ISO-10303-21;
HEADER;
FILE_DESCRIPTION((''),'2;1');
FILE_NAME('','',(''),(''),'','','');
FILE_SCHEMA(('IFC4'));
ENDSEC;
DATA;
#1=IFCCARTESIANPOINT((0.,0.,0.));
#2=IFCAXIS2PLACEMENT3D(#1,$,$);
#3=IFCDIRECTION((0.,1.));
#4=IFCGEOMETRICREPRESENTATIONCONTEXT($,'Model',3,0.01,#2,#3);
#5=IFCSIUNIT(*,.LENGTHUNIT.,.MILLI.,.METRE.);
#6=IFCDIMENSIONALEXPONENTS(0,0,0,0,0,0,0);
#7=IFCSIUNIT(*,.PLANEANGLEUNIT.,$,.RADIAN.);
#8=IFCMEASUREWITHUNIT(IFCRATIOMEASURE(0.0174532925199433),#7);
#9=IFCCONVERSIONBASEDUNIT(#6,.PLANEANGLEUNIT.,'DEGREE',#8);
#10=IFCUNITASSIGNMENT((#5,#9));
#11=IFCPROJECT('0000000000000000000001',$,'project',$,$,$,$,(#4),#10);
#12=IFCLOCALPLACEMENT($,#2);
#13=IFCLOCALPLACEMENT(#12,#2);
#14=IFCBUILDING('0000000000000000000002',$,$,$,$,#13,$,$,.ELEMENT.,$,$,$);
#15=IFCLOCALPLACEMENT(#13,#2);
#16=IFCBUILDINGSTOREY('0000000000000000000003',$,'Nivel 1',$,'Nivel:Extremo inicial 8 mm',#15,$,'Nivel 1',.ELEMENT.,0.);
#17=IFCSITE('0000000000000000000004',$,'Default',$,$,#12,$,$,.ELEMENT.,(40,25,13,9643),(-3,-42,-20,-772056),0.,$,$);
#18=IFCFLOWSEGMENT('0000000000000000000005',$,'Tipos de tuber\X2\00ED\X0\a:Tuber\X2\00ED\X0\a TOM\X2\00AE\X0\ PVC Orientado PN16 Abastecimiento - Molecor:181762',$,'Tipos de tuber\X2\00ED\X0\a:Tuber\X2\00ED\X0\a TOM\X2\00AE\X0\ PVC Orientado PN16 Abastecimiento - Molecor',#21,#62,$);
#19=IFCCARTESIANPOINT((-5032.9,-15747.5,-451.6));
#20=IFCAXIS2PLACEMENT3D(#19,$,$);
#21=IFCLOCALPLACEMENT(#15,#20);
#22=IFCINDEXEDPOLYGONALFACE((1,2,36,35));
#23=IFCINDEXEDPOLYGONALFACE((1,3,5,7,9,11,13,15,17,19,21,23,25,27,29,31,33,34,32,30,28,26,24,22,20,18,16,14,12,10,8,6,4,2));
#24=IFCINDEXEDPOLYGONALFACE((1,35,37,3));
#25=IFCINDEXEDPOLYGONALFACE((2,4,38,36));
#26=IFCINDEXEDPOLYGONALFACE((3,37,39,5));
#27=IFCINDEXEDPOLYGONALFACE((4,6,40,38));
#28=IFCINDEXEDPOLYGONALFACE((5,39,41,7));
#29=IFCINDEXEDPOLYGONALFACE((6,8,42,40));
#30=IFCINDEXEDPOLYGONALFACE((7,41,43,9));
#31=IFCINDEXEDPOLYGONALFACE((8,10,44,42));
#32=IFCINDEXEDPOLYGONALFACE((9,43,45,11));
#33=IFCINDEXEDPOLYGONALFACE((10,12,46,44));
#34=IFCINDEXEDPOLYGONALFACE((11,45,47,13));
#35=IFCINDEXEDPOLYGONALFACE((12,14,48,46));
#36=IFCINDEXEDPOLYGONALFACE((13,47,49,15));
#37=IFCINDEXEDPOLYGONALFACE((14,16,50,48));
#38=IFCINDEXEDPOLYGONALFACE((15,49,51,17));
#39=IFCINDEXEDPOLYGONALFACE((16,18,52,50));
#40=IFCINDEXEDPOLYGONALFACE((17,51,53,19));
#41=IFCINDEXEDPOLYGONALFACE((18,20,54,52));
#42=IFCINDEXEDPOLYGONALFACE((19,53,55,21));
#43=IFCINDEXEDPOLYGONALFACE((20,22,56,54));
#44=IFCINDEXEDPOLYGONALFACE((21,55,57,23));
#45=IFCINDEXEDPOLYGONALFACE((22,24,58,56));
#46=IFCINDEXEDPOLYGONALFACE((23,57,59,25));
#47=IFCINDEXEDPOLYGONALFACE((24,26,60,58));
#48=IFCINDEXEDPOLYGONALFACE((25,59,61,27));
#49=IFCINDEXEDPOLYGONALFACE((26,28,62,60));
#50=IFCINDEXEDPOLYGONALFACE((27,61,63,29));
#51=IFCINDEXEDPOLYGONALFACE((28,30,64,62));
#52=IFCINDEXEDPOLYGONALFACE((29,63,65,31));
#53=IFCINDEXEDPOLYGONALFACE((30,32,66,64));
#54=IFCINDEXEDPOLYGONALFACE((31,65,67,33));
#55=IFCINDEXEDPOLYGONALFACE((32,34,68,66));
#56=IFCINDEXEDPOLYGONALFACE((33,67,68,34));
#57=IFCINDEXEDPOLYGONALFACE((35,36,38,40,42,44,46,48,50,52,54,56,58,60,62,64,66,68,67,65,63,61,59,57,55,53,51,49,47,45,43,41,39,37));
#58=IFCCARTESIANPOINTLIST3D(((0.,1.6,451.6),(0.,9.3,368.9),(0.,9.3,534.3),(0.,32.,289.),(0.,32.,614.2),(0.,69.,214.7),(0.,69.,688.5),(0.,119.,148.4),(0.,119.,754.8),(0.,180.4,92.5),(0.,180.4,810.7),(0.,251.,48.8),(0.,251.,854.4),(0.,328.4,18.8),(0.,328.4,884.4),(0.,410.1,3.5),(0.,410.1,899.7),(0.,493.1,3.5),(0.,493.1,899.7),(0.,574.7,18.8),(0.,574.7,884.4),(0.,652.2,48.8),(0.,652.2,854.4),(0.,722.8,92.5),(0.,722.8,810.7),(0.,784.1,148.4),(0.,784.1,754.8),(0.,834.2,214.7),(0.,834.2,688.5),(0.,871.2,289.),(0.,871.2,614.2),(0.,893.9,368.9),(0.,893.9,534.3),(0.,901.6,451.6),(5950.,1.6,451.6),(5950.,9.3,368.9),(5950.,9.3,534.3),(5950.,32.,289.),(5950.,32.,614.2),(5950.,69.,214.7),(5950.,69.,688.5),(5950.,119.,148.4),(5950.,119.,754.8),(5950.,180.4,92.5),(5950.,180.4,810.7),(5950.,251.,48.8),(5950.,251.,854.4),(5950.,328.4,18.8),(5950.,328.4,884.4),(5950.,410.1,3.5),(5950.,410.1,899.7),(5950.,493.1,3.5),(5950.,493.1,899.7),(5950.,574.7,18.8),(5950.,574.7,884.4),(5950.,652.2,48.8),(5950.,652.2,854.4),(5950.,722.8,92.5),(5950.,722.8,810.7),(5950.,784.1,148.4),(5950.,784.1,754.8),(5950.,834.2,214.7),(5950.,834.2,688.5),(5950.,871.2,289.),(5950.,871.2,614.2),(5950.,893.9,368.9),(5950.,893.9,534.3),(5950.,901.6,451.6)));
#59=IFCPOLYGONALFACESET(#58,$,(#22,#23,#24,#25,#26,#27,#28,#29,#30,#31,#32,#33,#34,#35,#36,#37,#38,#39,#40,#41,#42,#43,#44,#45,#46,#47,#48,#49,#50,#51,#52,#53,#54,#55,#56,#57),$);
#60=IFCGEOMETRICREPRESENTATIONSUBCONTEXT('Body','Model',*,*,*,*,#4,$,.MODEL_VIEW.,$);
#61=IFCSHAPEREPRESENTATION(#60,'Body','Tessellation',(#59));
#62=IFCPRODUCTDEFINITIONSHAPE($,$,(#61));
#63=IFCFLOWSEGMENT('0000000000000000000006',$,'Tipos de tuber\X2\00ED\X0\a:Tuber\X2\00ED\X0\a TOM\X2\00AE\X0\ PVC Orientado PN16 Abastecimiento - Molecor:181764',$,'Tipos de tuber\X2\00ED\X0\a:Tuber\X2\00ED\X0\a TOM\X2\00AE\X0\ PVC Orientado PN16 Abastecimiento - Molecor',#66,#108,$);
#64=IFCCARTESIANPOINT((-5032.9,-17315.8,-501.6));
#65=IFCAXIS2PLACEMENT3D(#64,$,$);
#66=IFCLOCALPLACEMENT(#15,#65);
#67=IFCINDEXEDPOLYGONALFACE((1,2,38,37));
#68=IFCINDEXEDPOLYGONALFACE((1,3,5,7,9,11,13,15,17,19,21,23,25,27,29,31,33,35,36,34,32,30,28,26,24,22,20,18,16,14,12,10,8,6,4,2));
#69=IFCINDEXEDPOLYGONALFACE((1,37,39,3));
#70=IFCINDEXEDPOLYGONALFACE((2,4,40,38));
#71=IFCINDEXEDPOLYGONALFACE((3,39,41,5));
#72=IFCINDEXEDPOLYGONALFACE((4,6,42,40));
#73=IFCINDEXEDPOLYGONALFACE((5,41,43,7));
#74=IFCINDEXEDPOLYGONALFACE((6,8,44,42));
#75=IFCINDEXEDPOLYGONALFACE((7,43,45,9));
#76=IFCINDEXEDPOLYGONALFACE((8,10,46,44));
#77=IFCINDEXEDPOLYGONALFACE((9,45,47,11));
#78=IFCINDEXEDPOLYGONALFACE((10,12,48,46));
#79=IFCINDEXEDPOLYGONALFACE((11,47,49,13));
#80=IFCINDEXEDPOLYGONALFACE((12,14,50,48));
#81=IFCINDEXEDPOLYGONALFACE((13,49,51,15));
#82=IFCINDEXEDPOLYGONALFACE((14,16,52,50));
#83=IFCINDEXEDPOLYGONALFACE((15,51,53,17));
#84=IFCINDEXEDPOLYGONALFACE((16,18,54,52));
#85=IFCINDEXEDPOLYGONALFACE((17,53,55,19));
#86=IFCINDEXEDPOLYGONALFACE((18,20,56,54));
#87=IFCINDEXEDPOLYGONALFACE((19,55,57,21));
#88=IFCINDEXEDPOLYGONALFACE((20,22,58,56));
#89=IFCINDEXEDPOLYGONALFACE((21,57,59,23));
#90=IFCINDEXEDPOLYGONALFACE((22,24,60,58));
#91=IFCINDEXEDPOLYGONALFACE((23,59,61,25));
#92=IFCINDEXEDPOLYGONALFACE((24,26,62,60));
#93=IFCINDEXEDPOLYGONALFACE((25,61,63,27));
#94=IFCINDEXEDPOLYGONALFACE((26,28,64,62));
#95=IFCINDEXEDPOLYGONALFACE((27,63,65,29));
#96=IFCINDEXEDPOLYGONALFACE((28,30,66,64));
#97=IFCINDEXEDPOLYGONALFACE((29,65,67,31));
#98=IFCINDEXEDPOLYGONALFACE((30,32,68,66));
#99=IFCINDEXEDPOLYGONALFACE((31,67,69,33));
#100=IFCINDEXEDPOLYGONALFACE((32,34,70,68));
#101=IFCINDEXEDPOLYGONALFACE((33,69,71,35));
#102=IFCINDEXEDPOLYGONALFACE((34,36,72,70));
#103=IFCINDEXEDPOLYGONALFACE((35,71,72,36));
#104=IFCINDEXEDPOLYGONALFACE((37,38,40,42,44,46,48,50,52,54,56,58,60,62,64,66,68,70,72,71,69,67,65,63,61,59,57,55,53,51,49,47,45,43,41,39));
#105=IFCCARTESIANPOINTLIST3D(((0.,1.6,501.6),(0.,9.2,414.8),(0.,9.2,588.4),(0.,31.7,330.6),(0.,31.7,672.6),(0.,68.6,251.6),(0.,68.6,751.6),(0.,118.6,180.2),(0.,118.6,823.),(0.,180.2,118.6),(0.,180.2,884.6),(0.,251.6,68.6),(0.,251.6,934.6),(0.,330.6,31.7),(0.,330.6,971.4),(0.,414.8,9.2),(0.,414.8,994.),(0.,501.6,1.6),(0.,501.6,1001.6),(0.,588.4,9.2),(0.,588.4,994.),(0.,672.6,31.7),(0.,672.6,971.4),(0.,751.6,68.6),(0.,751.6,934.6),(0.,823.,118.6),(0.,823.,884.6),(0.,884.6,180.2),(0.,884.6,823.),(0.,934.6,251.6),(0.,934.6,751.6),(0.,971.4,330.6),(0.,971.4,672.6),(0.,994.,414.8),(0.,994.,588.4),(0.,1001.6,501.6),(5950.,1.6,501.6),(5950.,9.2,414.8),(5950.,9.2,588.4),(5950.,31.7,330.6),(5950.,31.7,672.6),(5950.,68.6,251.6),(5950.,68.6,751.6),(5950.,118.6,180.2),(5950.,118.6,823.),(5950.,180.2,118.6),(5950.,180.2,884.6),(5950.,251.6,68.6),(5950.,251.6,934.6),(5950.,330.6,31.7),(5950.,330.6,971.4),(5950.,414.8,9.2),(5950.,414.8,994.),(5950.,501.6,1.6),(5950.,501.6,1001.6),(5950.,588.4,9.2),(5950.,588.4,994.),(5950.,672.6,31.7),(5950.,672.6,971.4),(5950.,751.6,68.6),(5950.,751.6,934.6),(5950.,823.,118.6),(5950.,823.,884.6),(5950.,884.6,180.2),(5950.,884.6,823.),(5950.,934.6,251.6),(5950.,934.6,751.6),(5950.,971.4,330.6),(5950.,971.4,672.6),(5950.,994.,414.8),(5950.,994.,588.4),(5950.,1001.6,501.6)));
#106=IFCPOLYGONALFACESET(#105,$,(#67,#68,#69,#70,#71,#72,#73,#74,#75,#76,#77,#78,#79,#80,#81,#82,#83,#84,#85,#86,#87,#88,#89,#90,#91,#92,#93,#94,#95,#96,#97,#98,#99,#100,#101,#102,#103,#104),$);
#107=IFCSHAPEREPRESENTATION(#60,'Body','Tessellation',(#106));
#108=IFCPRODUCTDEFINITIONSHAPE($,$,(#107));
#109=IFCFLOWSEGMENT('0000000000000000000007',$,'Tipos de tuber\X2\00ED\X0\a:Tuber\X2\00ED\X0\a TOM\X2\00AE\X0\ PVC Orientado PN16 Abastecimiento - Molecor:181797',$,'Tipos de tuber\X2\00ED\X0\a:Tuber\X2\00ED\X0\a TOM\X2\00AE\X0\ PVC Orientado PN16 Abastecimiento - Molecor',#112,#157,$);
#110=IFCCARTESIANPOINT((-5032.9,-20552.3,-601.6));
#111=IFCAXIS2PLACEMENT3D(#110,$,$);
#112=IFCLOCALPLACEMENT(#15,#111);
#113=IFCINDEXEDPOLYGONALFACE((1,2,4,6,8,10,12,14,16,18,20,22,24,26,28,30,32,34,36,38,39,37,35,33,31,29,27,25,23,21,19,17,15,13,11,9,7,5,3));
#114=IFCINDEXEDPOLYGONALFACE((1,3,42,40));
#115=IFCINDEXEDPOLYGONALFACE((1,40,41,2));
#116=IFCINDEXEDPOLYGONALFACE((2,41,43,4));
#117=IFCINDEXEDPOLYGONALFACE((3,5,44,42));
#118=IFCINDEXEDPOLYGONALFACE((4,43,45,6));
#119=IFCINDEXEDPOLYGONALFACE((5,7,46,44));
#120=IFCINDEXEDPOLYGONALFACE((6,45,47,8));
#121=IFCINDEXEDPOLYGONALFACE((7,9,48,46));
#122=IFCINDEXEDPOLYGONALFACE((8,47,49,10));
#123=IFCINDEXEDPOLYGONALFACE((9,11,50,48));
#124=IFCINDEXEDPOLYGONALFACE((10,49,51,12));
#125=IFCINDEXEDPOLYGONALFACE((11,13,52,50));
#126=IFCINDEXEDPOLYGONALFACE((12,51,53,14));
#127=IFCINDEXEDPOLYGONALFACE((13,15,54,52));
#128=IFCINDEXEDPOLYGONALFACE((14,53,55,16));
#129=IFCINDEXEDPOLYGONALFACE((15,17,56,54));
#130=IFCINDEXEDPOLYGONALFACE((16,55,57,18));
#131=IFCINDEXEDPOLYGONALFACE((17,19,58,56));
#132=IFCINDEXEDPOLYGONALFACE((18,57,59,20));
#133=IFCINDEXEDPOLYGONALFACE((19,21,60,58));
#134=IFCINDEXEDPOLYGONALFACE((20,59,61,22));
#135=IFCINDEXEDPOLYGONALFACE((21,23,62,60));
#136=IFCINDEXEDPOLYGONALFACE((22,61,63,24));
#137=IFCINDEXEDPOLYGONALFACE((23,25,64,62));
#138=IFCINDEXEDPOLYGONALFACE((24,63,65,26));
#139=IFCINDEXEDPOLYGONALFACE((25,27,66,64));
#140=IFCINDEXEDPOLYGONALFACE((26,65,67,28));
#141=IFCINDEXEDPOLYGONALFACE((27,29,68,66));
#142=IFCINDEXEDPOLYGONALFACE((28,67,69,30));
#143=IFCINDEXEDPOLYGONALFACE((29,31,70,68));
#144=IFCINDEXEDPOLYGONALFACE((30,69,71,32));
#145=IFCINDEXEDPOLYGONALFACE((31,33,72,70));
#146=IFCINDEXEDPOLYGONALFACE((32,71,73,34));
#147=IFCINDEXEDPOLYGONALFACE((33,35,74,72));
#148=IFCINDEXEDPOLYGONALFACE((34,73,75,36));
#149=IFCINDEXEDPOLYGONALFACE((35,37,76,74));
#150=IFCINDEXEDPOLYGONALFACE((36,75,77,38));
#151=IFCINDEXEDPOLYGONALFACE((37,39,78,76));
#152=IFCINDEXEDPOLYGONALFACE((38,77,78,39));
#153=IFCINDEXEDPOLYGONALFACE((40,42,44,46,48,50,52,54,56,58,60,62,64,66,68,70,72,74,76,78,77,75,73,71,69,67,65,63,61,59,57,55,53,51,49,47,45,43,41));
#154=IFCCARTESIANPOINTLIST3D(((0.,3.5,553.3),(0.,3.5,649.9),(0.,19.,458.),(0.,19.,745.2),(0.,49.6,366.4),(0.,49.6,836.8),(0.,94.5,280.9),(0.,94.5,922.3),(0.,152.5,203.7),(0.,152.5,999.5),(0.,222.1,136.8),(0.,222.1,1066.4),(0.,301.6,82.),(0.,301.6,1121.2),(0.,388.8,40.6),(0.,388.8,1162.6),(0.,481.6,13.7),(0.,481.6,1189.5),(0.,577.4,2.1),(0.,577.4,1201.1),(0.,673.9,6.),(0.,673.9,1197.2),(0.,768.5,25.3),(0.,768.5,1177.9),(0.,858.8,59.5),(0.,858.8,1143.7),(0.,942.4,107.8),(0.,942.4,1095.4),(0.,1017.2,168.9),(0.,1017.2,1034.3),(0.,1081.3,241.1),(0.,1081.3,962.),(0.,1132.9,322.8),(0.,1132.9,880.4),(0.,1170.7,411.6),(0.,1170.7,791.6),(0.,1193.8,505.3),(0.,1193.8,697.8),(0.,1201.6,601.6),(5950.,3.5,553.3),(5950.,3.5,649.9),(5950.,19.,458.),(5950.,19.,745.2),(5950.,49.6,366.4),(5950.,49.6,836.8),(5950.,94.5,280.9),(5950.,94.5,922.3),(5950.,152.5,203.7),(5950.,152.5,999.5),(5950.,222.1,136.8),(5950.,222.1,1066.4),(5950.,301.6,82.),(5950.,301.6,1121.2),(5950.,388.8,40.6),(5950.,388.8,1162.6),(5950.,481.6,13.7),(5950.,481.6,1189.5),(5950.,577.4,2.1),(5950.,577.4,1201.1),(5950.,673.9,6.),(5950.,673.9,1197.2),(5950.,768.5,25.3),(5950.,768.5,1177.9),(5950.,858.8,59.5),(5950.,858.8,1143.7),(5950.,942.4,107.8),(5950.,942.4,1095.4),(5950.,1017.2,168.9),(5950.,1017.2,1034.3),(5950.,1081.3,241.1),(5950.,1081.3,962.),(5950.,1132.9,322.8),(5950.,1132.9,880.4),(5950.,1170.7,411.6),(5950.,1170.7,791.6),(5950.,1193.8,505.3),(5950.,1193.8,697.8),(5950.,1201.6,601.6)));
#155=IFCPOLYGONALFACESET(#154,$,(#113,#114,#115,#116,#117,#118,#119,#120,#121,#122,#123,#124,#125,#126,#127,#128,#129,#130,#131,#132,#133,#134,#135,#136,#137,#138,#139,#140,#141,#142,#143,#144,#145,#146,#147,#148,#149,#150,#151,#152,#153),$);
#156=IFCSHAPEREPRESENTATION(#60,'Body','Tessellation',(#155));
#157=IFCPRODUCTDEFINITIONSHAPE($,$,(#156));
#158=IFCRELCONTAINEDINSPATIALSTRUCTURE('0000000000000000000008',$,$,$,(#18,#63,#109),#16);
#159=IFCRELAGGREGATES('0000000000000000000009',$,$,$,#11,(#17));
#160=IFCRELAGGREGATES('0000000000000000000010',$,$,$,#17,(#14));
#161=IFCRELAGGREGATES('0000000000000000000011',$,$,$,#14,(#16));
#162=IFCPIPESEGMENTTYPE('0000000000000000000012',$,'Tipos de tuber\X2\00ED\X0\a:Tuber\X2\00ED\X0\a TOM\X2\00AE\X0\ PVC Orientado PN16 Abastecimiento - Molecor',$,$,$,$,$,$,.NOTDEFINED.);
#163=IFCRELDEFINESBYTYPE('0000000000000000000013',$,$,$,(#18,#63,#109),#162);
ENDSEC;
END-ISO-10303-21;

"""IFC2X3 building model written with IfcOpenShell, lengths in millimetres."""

from ifc_helpers import new_model, entity, si_unit, converted_unit, direction, frame, frame_2d, origin, place, context, subcontext, project, spatial, circle, extrude, type_object, element, save


model = new_model("IFC2X3")

# Units and contexts
model_context = context("Model", 3, precision=0.01, world=origin(), true_north=direction((0.0, 1.0)))
body_context = subcontext(model_context, "Body", "Model", "MODEL_VIEW")
ifc_project = project(units=[si_unit("LENGTHUNIT", "METRE", prefix="MILLI"), converted_unit("PLANEANGLEUNIT", "DEGREE", entity("IfcRatioMeasure", 0.0174532925199433), si_unit("PLANEANGLEUNIT", "RADIAN"), dimensions=[0, 0, 0, 0, 0, 0, 0])], contexts=[model_context])

# Site, building, storey
site_placement = place(None, origin())
site = spatial("IfcSite", under=ifc_project, at=site_placement, Name="Default", CompositionType="ELEMENT", RefLatitude=(40, 25, 13, 9643), RefLongitude=(-3, -42, -20, -772056), RefElevation=0.0)
building_placement = place(site_placement, origin())
building = spatial("IfcBuilding", under=site, at=building_placement, CompositionType="ELEMENT")
storey_placement = place(building_placement, origin())
storey = spatial("IfcBuildingStorey", under=building, at=storey_placement, Name="Nivel 1", ObjectType="Nivel:Extremo inicial 8 mm", LongName="Nivel 1", CompositionType="ELEMENT", Elevation=0.0)

# Flow segments
pipe_segment_type_1 = type_object("IfcPipeSegmentType", Name="Tipos de tubería:Tubería TOM® PVC Orientado PN16 Abastecimiento - Molecor", PredefinedType="NOTDEFINED")
flow_segment_1_placement = place(storey_placement, frame((-5032.9, -15747.5, -451.6)))
element("IfcFlowSegment", 1, at=flow_segment_1_placement, inside=storey, type_object=pipe_segment_type_1, Name="Tipos de tubería:Tubería TOM® PVC Orientado PN16 Abastecimiento - Molecor:181762", ObjectType="Tipos de tubería:Tubería TOM® PVC Orientado PN16 Abastecimiento - Molecor", context=body_context, shape_type="SweptSolid", body=[
    extrude(circle(Radius=450.0, at=frame_2d((0.0, 0.0), x_axis=(1.0, 0.0))), frame((0.0, 451.6, 451.6), z_axis=(1.0, 0.0, 0.0), x_axis=(0.0, 1.0, 0.0)), (0.0, 0.0, 1.0), 5950.0),
])
flow_segment_2_placement = place(storey_placement, frame((-5032.9, -17315.8, -501.6)))
element("IfcFlowSegment", 2, at=flow_segment_2_placement, inside=storey, type_object=pipe_segment_type_1, Name="Tipos de tubería:Tubería TOM® PVC Orientado PN16 Abastecimiento - Molecor:181764", ObjectType="Tipos de tubería:Tubería TOM® PVC Orientado PN16 Abastecimiento - Molecor", context=body_context, shape_type="SweptSolid", body=[
    extrude(circle(Radius=500.0, at=frame_2d((0.0, 0.0), x_axis=(1.0, 0.0))), frame((0.0, 501.6, 501.6), z_axis=(1.0, 0.0, 0.0), x_axis=(0.0, 1.0, 0.0)), (0.0, 0.0, 1.0), 5950.0),
])
flow_segment_3_placement = place(storey_placement, frame((-5032.9, -20552.3, -601.6)))
element("IfcFlowSegment", 3, at=flow_segment_3_placement, inside=storey, type_object=pipe_segment_type_1, Name="Tipos de tubería:Tubería TOM® PVC Orientado PN16 Abastecimiento - Molecor:181797", ObjectType="Tipos de tubería:Tubería TOM® PVC Orientado PN16 Abastecimiento - Molecor", context=body_context, shape_type="SweptSolid", body=[
    extrude(circle(Radius=600.0, at=frame_2d((0.0, 0.0), x_axis=(1.0, 0.0))), frame((0.0, 601.6, 601.6), z_axis=(1.0, 0.0, 0.0), x_axis=(0.0, 1.0, 0.0)), (0.0, 0.0, 1.0), 5950.0),
])

save(model, "model.ifc")
